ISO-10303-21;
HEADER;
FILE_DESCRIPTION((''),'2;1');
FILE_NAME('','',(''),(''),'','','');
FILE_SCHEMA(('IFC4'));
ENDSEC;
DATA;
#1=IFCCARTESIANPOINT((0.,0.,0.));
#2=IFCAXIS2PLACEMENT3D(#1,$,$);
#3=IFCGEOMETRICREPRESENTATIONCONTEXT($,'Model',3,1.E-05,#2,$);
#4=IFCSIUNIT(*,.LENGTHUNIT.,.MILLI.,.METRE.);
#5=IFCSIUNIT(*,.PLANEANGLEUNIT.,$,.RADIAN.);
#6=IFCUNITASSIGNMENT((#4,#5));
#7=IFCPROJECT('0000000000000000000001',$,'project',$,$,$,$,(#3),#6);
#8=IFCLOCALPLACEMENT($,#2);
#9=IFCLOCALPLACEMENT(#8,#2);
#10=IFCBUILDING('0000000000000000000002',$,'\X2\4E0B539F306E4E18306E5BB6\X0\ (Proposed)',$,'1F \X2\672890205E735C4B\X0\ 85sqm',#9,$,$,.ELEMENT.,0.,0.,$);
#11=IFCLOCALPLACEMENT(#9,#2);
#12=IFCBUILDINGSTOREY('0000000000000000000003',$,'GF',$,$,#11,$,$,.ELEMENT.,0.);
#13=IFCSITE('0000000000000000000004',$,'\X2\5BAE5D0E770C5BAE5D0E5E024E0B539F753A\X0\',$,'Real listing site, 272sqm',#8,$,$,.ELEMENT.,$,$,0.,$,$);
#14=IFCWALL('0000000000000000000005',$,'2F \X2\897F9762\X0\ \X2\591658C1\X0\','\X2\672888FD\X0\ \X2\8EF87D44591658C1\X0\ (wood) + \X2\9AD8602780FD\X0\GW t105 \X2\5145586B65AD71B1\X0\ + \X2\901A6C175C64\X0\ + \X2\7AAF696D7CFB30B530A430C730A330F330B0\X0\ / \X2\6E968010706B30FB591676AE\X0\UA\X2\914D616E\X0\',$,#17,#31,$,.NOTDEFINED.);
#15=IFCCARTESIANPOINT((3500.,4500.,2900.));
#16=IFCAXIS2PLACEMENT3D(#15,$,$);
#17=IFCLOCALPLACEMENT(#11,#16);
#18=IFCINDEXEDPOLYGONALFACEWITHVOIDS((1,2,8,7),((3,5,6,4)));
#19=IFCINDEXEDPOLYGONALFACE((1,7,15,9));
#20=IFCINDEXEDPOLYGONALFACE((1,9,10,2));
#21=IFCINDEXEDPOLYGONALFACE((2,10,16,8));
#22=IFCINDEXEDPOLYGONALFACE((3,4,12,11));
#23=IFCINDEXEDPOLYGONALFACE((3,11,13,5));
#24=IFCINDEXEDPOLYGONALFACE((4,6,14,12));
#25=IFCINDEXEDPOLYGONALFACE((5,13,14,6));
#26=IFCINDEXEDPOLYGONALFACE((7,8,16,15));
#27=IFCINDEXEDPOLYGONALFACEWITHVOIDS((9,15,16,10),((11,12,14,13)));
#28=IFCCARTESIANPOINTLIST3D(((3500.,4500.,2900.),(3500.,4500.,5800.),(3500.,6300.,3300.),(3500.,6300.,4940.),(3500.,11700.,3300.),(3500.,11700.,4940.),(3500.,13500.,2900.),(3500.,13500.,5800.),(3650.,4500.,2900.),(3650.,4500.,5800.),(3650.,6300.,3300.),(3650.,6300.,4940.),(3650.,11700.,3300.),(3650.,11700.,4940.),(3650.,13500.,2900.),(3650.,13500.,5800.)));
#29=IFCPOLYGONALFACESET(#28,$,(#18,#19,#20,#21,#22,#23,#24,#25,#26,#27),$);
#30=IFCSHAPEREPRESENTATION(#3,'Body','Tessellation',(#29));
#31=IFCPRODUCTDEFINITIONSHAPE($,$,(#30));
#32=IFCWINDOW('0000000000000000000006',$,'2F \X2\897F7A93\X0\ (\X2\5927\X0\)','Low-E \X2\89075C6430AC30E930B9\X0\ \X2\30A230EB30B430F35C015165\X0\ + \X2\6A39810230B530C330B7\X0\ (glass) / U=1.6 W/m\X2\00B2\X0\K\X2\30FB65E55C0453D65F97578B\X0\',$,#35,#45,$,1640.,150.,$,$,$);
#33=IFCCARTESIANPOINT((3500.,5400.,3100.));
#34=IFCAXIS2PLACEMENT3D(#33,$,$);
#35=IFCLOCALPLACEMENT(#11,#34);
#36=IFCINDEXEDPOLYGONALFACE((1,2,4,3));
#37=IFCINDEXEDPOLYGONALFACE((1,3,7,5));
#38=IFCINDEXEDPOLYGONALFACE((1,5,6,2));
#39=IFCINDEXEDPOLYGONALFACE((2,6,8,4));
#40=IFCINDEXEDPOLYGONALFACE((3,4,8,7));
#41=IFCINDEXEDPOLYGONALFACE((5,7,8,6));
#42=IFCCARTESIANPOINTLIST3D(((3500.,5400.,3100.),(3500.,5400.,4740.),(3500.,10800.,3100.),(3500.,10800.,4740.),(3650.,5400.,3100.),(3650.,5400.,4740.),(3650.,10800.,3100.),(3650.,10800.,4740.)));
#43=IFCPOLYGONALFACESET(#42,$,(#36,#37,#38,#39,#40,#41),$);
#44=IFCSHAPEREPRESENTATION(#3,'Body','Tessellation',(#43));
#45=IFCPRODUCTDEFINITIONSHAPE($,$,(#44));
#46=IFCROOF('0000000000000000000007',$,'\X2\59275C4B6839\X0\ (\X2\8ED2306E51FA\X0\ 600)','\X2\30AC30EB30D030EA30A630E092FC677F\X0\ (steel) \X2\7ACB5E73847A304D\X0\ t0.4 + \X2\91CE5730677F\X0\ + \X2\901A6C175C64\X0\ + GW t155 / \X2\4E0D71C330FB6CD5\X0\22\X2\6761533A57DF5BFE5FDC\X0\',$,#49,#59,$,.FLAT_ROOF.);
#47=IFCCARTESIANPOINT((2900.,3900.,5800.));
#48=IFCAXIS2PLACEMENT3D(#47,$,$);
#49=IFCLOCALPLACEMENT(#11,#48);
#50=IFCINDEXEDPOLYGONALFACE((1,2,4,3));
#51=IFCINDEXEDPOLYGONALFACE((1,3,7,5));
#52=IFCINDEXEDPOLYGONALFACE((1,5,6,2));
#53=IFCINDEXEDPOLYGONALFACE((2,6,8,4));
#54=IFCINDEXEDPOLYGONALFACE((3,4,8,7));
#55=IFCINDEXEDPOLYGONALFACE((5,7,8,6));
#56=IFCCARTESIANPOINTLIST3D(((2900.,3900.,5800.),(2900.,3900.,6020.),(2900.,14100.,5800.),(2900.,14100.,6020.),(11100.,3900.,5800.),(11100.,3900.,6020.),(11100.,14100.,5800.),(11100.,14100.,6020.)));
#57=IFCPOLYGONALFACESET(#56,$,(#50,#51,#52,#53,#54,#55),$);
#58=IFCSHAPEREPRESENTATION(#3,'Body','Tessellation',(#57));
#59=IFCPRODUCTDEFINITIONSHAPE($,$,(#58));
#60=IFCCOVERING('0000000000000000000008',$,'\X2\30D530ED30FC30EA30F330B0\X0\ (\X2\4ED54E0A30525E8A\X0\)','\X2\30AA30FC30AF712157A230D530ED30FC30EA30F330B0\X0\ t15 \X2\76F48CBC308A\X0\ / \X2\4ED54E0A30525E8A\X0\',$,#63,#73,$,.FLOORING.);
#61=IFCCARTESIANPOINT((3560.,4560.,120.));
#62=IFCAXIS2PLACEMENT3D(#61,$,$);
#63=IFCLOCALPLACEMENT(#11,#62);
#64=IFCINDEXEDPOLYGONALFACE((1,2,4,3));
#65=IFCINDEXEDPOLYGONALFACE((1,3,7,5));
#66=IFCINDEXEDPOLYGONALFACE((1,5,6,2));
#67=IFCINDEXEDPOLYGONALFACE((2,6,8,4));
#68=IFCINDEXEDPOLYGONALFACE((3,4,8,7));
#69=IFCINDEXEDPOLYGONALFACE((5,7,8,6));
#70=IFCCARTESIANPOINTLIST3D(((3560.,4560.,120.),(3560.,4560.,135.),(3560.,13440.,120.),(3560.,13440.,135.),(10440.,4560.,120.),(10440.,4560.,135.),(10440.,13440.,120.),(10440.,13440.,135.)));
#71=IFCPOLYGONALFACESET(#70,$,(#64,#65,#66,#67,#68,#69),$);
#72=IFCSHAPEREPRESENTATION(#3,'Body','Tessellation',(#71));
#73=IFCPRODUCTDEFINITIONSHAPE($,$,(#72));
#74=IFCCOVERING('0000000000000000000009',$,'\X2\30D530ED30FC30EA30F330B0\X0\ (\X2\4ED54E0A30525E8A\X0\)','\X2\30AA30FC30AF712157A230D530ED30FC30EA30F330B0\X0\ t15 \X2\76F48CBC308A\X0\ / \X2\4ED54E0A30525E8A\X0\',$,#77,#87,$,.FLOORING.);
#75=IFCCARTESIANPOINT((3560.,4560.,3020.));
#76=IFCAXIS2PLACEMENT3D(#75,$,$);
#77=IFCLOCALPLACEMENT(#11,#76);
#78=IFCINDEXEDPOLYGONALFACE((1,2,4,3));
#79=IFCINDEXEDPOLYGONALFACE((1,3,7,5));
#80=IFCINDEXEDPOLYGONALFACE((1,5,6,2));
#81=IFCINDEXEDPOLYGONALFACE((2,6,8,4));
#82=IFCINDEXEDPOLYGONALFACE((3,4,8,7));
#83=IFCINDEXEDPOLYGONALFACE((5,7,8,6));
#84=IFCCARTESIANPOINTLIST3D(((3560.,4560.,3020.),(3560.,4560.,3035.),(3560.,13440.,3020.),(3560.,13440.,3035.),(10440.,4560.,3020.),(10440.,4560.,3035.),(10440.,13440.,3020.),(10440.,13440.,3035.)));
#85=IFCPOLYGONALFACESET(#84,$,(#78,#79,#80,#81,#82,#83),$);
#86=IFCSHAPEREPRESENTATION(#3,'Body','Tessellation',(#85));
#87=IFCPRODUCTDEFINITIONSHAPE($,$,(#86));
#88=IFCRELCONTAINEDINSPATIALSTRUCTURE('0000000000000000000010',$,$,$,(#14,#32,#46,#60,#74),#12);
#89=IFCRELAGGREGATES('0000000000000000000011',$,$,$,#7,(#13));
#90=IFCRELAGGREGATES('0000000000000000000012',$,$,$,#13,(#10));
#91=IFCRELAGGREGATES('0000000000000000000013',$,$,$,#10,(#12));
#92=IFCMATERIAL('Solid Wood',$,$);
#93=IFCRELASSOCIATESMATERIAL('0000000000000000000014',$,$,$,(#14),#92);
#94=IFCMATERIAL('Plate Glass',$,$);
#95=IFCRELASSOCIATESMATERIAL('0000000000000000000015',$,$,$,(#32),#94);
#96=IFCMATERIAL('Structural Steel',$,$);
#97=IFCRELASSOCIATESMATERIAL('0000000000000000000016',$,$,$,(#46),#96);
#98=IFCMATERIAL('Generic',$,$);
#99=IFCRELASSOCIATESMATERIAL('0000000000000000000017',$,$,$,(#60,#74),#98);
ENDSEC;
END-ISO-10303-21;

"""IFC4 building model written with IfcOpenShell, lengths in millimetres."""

from ifc_helpers import new_model, si_unit, frame, frame_2d, origin, place, context, project, spatial, rectangle, extrude, material, element, fill, save


model = new_model("IFC4")

# Units and contexts
model_context = context("Model", 3, precision=1e-05, world=origin())
ifc_project = project(units=[si_unit("LENGTHUNIT", "METRE", prefix="MILLI"), si_unit("PLANEANGLEUNIT", "RADIAN")], contexts=[model_context])

# Site, building, storey
site_placement = place(None, origin())
site = spatial("IfcSite", under=ifc_project, at=site_placement, Name="宮崎県宮崎市下原町", ObjectType="Real listing site, 272sqm", CompositionType="ELEMENT", RefElevation=0.0)
building_placement = place(site_placement, origin())
building = spatial("IfcBuilding", under=site, at=building_placement, Name="下原の丘の家 (Proposed)", ObjectType="1F 木造平屋 85sqm", CompositionType="ELEMENT", ElevationOfRefHeight=0.0, ElevationOfTerrain=0.0)
storey_placement = place(building_placement, origin())
storey = spatial("IfcBuildingStorey", under=building, at=storey_placement, Name="GF", CompositionType="ELEMENT", Elevation=0.0)

# Shared definitions
ifc_material_1 = material(Name="Solid Wood")
ifc_material_2 = material(Name="Generic")

# Shared definitions
ifc_material_3 = material(Name="Plate Glass")

# Wall, opening, window
wall_1_placement = place(storey_placement, frame((3500.0, 4500.0, 2900.0)))
wall_1 = element("IfcWall", 1, at=wall_1_placement, inside=storey, material=ifc_material_1, Name="2F 西面 外壁", Description="木製 軸組外壁 (wood) + 高性能GW t105 充填断熱 + 通気層 + 窯業系サイディング / 準耐火・外皮UA配慮", PredefinedType="NOTDEFINED", context=model_context, shape_type="SweptSolid", body=[
    extrude(rectangle(XDim=150.0, YDim=9000.0, at=frame_2d((75.0, 4500.0))), frame((3500.0, 4500.0, 2900.0)), (0.0, 0.0, 1.0), 2900.0),
])
opening_1_placement = place(storey_placement, frame((3500.0, 5400.0, 3100.0)))
opening_1 = element("IfcOpeningElement", 2, at=opening_1_placement, cuts=wall_1, PredefinedType="NOTDEFINED", context=model_context, shape_type="SweptSolid", body=[
    extrude(rectangle(XDim=150.0, YDim=5400.0, at=frame_2d((75.0, 2700.0))), frame((3500.0, 5400.0, 3100.0)), (0.0, 0.0, 1.0), 1640.0),
])
window_1_placement = place(storey_placement, frame((3500.0, 5400.0, 3100.0)))
window_1 = element("IfcWindow", 3, at=window_1_placement, inside=storey, material=ifc_material_3, Name="2F 西窓 (大)", Description="Low-E 複層ガラス アルゴン封入 + 樹脂サッシ (glass) / U=1.6 W/m²K・日射取得型", OverallHeight=1640.0, OverallWidth=150.0, context=model_context, shape_type="SweptSolid", body=[
    extrude(rectangle(XDim=150.0, YDim=5400.0, at=frame_2d((75.0, 2700.0))), frame((3500.0, 5400.0, 3100.0)), (0.0, 0.0, 1.0), 1640.0),
])
fill(opening_1, window_1)

# Roof
ifc_material_4 = material(Name="Structural Steel")
roof_placement = place(storey_placement, frame((2900.0, 3900.0, 5800.0)))
element("IfcRoof", 4, at=roof_placement, inside=storey, material=ifc_material_4, Name="大屋根 (軒の出 600)", Description="ガルバリウム鋼板 (steel) 立平葺き t0.4 + 野地板 + 通気層 + GW t155 / 不燃・法22条区域対応", PredefinedType="FLAT_ROOF", context=model_context, shape_type="SweptSolid", body=[
    extrude(rectangle(XDim=8200.0, YDim=10200.0, at=frame_2d((4100.0, 5100.0))), frame((2900.0, 3900.0, 5800.0)), (0.0, 0.0, 1.0), 220.0),
])

# Coverings
covering_1_placement = place(storey_placement, frame((3560.0, 4560.0, 120.0)))
element("IfcCovering", 5, at=covering_1_placement, inside=storey, material=ifc_material_2, Name="フローリング (仕上げ床)", Description="オーク無垢フローリング t15 直貼り / 仕上げ床", PredefinedType="FLOORING", context=model_context, shape_type="SweptSolid", body=[
    extrude(rectangle(XDim=6880.0, YDim=8880.0, at=frame_2d((3440.0, 4440.0))), frame((3560.0, 4560.0, 120.0)), (0.0, 0.0, 1.0), 15.0),
])
covering_2_placement = place(storey_placement, frame((3560.0, 4560.0, 3020.0)))
element("IfcCovering", 6, at=covering_2_placement, inside=storey, material=ifc_material_2, Name="フローリング (仕上げ床)", Description="オーク無垢フローリング t15 直貼り / 仕上げ床", PredefinedType="FLOORING", context=model_context, shape_type="SweptSolid", body=[
    extrude(rectangle(XDim=6880.0, YDim=8880.0, at=frame_2d((3440.0, 4440.0))), frame((3560.0, 4560.0, 3020.0)), (0.0, 0.0, 1.0), 15.0),
])

save(model, "model.ifc")
